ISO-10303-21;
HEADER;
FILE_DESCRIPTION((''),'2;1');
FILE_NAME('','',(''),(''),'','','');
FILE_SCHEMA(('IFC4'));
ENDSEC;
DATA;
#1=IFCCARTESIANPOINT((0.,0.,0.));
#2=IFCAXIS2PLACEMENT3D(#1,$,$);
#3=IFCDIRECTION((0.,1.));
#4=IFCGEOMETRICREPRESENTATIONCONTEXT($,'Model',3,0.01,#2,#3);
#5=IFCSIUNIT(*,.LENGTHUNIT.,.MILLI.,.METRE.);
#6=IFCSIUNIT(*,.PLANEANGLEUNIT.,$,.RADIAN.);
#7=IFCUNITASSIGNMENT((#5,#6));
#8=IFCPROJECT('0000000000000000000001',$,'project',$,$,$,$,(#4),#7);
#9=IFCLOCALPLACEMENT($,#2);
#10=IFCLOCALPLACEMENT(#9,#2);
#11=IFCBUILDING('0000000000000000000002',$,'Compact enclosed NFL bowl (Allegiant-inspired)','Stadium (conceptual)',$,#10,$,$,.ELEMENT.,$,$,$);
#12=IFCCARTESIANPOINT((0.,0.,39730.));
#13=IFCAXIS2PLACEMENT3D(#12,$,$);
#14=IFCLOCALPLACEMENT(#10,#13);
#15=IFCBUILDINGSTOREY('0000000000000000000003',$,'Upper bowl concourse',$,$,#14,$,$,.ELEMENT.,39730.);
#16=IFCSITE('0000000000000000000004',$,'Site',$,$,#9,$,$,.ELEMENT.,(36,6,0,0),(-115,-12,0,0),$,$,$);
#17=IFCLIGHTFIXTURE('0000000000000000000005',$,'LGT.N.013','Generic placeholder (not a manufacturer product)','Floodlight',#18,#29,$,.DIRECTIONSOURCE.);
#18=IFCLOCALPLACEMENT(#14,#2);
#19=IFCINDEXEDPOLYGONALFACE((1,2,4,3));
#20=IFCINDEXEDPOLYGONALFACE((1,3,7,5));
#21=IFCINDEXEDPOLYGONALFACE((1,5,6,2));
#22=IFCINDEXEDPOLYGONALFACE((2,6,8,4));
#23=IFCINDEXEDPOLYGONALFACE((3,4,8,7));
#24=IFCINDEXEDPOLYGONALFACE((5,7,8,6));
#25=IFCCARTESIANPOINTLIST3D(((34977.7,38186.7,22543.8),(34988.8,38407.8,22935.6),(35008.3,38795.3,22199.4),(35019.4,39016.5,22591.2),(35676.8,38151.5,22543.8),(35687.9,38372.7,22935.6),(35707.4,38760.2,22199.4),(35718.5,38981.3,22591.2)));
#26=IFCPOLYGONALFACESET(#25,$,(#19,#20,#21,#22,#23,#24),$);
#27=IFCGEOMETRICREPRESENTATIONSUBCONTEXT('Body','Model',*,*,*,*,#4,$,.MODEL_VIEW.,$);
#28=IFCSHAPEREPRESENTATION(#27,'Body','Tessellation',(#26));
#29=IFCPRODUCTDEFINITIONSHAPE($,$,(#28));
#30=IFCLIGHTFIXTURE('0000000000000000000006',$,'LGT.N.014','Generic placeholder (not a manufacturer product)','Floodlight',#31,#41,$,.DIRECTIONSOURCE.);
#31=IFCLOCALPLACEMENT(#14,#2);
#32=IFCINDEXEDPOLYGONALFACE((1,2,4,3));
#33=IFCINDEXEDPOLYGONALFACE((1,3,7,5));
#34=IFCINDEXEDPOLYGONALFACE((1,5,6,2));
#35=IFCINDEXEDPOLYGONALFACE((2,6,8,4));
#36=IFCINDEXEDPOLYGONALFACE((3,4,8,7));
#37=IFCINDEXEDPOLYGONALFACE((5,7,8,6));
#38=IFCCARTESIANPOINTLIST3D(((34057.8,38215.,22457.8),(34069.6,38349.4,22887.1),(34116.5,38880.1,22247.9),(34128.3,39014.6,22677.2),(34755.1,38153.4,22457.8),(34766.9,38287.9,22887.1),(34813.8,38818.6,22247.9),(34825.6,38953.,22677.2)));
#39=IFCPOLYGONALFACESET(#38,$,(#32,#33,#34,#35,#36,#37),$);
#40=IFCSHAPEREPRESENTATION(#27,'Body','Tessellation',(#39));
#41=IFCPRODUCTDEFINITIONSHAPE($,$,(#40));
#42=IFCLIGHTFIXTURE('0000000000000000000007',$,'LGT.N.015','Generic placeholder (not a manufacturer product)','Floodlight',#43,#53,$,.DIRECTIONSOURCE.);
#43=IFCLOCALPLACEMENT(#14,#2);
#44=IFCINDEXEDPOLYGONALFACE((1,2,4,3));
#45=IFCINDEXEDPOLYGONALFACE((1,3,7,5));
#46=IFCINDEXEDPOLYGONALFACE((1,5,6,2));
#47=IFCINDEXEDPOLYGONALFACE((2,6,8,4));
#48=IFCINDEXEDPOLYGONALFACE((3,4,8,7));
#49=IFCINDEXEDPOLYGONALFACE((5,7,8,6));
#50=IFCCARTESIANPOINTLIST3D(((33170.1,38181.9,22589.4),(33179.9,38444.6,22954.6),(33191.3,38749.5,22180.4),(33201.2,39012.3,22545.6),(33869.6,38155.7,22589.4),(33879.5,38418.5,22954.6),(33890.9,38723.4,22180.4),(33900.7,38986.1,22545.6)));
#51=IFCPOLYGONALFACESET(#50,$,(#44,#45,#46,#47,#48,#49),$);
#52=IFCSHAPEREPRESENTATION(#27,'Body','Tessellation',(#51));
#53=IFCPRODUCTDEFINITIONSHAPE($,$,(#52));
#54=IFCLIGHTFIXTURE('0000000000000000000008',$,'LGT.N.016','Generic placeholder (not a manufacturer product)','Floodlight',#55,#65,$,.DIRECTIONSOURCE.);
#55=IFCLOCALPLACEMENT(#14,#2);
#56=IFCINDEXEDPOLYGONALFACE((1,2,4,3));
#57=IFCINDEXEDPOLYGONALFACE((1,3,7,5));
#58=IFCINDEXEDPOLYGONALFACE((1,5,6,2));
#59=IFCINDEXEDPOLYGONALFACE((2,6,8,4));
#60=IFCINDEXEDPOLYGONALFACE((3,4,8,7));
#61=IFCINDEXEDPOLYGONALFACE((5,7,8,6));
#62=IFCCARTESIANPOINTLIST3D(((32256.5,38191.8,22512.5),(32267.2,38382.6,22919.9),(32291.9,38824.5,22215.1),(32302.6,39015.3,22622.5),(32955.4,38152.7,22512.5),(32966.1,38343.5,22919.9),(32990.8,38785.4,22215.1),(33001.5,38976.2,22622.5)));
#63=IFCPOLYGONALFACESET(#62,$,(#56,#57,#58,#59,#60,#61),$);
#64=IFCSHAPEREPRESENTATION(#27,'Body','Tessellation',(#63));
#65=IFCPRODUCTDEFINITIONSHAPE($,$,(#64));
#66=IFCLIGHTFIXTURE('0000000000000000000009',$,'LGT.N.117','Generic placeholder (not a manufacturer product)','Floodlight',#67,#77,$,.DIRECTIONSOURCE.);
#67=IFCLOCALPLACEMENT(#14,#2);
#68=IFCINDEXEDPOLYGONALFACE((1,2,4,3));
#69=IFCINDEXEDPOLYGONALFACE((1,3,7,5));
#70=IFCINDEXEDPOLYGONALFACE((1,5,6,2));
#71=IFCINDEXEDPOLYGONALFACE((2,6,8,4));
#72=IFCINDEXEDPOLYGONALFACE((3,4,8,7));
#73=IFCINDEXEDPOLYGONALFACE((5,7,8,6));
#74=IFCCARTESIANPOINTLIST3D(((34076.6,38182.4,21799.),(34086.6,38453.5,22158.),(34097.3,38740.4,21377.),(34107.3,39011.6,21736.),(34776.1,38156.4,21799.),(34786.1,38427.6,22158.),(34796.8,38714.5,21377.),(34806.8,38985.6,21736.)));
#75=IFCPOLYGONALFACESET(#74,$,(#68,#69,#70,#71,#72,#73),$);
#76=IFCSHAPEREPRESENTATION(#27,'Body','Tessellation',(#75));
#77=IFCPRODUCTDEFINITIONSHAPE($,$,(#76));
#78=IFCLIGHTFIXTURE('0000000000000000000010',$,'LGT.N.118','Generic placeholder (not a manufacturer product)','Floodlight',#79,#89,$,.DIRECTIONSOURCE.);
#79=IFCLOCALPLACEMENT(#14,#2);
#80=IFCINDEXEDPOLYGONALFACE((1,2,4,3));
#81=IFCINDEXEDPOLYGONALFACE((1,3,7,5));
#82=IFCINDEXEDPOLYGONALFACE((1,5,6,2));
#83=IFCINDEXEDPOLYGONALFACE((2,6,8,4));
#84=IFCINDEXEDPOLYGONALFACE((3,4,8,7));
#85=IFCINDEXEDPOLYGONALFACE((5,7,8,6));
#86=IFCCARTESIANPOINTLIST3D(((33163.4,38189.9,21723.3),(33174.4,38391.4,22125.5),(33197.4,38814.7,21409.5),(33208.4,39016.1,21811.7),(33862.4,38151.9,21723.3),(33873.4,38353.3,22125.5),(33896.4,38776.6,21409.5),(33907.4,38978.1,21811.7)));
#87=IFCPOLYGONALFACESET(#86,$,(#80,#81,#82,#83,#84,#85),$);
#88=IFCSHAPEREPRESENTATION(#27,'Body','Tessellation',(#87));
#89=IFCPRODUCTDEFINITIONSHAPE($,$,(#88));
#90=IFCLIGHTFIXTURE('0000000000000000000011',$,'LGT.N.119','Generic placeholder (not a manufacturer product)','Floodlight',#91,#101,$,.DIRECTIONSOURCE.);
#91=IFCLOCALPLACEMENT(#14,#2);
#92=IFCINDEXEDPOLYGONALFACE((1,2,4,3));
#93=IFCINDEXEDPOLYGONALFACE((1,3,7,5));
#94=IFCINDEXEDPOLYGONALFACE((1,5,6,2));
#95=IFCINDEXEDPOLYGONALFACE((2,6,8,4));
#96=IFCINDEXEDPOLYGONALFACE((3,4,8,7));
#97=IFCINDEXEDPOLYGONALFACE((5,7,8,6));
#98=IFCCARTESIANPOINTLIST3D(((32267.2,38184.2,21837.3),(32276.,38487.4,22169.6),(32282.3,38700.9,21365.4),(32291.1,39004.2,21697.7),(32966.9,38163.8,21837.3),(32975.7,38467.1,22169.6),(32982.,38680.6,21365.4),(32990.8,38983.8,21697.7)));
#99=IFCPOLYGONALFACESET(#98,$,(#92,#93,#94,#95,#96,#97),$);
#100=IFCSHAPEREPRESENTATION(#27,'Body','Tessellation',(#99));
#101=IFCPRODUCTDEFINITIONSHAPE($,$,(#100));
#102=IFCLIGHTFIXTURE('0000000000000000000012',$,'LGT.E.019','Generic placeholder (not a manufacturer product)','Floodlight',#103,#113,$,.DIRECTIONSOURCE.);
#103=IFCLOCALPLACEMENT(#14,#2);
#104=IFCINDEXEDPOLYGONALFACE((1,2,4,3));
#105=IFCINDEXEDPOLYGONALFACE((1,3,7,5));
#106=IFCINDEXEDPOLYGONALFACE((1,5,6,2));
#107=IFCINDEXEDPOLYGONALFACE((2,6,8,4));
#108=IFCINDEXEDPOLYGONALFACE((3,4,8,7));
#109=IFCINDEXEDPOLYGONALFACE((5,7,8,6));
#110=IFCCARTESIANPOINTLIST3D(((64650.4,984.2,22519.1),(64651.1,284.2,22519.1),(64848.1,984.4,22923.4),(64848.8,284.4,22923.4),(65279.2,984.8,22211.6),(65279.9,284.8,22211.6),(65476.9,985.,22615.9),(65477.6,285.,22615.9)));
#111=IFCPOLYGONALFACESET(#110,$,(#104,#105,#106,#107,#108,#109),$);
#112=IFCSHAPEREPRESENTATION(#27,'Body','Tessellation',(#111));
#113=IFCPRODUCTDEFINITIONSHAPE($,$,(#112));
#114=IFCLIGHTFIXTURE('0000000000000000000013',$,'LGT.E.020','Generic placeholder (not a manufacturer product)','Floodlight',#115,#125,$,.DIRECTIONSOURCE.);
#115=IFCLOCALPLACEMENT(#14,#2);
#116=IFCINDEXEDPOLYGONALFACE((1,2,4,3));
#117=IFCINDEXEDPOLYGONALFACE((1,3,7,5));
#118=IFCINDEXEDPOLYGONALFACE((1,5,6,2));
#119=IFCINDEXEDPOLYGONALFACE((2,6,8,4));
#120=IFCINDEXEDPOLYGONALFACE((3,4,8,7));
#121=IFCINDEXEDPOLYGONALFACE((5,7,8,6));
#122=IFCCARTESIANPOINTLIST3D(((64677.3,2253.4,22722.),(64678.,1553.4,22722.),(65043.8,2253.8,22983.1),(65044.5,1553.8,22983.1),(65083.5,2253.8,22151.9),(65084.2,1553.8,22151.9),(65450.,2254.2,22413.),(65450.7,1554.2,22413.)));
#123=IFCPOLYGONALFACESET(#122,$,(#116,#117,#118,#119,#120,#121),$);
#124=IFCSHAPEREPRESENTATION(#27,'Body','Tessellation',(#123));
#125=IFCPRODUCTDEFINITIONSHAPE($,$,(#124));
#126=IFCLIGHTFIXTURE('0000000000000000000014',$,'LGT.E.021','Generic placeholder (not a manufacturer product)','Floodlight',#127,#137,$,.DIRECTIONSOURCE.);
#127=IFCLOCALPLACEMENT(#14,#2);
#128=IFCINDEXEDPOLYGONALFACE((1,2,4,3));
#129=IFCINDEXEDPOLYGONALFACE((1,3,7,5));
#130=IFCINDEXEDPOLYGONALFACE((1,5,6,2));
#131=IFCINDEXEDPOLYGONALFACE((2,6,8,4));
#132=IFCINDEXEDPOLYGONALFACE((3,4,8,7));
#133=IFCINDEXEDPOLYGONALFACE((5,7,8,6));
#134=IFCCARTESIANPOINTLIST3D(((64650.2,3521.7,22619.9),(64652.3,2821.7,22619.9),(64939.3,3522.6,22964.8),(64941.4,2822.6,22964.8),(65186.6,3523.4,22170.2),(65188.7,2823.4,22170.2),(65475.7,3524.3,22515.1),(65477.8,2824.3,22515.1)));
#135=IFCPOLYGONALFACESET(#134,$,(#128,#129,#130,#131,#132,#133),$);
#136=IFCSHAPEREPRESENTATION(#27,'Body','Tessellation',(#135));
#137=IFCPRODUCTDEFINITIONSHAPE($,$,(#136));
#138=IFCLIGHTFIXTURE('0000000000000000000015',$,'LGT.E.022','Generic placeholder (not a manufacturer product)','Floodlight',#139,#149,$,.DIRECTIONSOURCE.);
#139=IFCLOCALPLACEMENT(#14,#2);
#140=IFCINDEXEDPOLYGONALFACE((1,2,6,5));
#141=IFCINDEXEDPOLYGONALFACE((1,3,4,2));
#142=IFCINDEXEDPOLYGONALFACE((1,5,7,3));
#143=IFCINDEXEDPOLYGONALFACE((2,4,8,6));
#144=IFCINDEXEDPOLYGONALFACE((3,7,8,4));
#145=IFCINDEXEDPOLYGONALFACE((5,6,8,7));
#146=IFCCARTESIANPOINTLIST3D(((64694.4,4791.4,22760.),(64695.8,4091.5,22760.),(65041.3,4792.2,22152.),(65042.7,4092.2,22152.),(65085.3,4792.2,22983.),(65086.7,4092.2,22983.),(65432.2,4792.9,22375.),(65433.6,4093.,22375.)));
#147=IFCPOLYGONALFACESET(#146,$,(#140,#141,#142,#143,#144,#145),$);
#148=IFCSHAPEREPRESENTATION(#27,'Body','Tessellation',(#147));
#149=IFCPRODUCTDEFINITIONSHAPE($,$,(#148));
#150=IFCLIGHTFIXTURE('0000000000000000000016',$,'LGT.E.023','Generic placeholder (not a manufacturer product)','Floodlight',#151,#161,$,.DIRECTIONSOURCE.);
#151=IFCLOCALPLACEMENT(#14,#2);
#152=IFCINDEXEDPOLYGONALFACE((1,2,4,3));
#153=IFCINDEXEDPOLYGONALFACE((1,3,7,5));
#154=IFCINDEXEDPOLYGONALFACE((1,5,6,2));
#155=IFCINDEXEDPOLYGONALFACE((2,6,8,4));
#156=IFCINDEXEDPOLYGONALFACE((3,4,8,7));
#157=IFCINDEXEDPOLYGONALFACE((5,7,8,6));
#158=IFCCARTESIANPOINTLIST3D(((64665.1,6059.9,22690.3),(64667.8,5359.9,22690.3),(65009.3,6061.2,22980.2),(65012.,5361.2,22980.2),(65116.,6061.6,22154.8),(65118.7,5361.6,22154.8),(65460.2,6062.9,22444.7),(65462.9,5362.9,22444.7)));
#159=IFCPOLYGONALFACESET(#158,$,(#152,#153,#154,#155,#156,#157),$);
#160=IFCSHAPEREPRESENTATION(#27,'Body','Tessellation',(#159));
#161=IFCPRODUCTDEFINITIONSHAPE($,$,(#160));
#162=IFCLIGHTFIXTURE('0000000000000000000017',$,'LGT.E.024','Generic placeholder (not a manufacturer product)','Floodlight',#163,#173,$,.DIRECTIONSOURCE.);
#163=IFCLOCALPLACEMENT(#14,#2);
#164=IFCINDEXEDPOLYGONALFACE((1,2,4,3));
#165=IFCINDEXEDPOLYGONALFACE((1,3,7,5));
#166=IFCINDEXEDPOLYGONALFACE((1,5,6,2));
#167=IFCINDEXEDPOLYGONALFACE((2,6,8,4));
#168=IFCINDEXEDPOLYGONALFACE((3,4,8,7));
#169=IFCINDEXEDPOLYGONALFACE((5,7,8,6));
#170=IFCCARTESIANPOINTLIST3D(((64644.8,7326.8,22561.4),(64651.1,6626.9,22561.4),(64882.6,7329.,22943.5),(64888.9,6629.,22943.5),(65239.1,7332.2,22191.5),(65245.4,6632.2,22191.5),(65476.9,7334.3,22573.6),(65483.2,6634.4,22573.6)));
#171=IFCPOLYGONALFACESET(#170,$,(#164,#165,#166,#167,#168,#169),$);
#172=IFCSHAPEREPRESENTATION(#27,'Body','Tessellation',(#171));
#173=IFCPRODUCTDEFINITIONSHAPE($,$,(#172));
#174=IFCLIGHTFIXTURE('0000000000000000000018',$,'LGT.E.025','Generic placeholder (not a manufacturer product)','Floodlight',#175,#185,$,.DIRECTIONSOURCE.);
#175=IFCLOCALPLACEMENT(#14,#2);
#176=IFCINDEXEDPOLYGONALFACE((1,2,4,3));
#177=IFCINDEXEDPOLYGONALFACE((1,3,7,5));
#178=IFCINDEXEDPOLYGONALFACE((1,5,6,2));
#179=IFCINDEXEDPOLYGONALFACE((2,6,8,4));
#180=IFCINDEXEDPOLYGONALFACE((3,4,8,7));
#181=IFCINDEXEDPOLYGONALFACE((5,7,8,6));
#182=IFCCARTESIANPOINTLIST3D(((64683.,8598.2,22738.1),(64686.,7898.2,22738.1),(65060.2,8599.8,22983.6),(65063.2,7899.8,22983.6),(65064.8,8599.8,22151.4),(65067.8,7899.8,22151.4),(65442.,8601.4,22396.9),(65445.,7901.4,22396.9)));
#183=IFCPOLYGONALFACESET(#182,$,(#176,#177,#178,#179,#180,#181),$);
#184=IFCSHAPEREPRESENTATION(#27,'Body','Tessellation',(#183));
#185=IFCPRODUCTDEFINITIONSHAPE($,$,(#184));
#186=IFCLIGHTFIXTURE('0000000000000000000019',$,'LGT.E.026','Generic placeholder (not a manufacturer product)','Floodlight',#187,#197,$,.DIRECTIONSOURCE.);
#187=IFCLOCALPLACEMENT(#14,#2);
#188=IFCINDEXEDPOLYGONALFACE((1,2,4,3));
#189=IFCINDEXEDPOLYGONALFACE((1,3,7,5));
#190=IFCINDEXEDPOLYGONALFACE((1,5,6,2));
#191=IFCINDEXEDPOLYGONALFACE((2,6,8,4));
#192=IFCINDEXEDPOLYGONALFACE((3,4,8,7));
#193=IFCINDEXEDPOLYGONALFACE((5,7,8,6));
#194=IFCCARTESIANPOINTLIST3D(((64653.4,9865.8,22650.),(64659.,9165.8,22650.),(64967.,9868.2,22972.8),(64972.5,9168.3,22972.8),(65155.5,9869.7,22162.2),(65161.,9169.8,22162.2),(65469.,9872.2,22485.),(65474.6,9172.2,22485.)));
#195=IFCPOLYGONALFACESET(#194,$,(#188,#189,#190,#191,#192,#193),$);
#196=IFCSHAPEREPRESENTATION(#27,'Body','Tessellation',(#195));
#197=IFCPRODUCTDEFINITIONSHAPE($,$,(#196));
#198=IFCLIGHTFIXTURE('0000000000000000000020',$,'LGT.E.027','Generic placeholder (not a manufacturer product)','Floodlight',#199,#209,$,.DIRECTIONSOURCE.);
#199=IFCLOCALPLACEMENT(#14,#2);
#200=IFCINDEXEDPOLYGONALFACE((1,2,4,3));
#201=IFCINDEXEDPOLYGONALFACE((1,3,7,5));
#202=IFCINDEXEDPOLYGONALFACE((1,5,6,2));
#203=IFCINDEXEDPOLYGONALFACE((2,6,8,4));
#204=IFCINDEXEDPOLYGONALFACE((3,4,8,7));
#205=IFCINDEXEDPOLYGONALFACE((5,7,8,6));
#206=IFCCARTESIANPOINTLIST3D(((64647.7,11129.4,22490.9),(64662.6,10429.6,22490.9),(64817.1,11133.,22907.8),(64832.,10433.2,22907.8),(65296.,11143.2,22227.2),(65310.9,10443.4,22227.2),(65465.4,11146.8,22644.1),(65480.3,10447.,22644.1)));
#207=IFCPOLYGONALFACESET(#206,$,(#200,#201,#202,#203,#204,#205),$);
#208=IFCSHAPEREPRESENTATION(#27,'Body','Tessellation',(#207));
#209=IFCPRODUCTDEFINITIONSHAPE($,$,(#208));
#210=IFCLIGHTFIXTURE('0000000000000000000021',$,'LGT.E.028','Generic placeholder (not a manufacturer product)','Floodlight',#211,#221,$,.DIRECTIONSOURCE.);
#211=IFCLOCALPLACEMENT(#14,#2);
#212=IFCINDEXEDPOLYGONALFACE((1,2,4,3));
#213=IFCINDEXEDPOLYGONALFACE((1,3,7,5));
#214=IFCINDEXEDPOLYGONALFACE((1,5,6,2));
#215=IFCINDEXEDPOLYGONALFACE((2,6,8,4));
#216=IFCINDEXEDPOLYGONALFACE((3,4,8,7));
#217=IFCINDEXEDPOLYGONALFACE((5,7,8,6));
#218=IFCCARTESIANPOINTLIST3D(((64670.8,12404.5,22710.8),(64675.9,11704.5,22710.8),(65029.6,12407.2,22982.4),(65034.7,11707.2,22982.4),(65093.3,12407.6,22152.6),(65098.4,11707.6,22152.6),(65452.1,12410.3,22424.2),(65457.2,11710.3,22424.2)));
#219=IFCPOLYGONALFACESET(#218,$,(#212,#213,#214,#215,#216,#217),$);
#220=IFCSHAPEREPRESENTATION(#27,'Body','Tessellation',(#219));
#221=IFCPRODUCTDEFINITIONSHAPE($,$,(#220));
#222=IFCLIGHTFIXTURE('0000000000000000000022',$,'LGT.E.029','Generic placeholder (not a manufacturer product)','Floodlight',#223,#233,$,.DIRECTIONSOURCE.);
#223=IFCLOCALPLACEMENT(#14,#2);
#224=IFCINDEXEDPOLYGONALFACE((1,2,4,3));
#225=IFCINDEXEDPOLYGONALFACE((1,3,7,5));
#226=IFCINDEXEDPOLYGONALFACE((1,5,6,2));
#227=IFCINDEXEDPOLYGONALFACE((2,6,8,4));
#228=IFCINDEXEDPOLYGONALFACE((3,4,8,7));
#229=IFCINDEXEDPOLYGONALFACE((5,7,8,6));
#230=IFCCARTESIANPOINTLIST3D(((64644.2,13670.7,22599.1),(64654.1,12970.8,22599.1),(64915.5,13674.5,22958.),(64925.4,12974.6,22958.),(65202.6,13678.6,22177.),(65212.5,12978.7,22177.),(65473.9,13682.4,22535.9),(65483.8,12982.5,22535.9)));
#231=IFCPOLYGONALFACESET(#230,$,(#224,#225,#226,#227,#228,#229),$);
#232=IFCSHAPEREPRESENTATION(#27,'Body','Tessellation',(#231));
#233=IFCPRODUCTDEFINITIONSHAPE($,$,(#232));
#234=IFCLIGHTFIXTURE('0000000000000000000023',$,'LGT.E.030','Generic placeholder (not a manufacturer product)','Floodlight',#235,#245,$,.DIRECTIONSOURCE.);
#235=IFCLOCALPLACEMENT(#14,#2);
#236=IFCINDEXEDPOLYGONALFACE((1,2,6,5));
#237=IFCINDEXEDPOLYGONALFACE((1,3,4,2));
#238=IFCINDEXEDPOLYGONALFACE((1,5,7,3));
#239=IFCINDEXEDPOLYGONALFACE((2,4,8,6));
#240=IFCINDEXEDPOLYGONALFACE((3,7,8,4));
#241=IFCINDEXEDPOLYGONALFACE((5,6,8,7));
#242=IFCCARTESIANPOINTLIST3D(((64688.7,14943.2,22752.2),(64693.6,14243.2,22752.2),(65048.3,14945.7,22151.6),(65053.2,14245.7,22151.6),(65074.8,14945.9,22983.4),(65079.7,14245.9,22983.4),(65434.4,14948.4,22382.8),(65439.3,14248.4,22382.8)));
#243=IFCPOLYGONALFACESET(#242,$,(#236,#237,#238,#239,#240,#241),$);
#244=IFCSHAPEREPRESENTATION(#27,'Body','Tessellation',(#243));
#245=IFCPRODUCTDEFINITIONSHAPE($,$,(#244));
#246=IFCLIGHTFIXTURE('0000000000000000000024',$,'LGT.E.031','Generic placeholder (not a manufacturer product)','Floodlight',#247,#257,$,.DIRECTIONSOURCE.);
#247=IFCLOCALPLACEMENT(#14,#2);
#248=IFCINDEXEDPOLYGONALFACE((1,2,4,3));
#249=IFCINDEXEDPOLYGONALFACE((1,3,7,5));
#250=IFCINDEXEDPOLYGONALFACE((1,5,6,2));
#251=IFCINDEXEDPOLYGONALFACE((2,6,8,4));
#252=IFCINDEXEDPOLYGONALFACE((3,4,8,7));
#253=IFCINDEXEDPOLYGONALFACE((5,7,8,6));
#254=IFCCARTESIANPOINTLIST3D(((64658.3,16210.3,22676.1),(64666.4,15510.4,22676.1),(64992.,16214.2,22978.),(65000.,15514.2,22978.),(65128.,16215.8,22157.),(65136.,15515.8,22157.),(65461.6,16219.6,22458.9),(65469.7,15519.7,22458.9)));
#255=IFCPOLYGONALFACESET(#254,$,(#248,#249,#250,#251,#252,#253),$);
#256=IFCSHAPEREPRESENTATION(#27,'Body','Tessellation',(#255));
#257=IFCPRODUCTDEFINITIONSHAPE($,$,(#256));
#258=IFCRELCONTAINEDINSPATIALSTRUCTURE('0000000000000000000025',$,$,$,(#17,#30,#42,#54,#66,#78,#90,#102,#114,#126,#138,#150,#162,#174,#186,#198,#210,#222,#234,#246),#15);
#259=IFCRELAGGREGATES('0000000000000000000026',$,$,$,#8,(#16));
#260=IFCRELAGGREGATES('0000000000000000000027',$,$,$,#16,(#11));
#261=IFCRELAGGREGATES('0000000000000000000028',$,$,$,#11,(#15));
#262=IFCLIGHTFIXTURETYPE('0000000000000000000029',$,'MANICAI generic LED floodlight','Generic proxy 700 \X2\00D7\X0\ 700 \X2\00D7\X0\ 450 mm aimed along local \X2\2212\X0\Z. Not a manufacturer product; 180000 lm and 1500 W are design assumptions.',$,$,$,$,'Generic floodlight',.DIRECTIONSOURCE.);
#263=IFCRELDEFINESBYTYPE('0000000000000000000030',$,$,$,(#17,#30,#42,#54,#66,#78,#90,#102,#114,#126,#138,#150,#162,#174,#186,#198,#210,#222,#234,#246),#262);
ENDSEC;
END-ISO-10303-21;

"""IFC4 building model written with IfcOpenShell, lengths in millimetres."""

from ifc_helpers import new_model, si_unit, direction, frame, origin, place, context, subcontext, project, spatial, rectangle, extrude, source, transform, mapped, type_object, type_shapes, element, save


model = new_model("IFC4")

# Units and contexts
model_context = context("Model", 3, precision=0.01, world=origin(), true_north=direction((0.0, 1.0)))
body_context = subcontext(model_context, "Body", "Model", "MODEL_VIEW")
ifc_project = project(units=[si_unit("LENGTHUNIT", "METRE", prefix="MILLI"), si_unit("PLANEANGLEUNIT", "RADIAN")], contexts=[model_context])

# Site, building, storey
site_placement = place(None, origin())
site = spatial("IfcSite", under=ifc_project, at=site_placement, Name="Site", CompositionType="ELEMENT", RefLatitude=(36, 6, 0, 0), RefLongitude=(-115, -12, 0, 0))
building_placement = place(site_placement, origin())
building = spatial("IfcBuilding", under=site, at=building_placement, Name="Compact enclosed NFL bowl (Allegiant-inspired)", Description="Stadium (conceptual)", CompositionType="ELEMENT")
storey_placement = place(building_placement, frame((0.0, 0.0, 39730.0)))
storey = spatial("IfcBuildingStorey", under=building, at=storey_placement, Name="Upper bowl concourse", CompositionType="ELEMENT", Elevation=39730.0)

# Light fixtures
light_fixture_type = type_object("IfcLightFixtureType", Name="MANICAI generic LED floodlight", Description="Generic proxy 700 × 700 × 450 mm aimed along local −Z. Not a manufacturer product; 180000 lm and 1500 W are design assumptions.", ElementType="Generic floodlight", PredefinedType="DIRECTIONSOURCE")
shared_shape = source(origin(), body_context, "Body", "SweptSolid", [
    extrude(rectangle(XDim=700.0, YDim=700.0), frame((0.0, 0.0, -225.0)), (0.0, 0.0, 1.0), 450.0),
])
type_shapes(light_fixture_type, [shared_shape])
for number, where, z_axis, x_axis, name in (
    (1, (35348.1, 38584.0, 22567.5), (0.0247, 0.491356, 0.870608), (-0.998739, 0.050205, 0.0), "LGT.N.013"),
    (2, (34441.7, 38584.0, 22567.5), (0.02637, 0.29879, 0.953954), (-0.996128, 0.087914, 0.0), "LGT.N.014"),
    (3, (33535.4, 38584.0, 22567.5), (0.021842, 0.583959, 0.811489), (-0.999301, 0.037377, 0.0), "LGT.N.015"),
    (4, (32629.0, 38584.0, 22567.5), (0.023708, 0.424088, 0.905311), (-0.998441, 0.055817, 0.0), "LGT.N.016"),
    (5, (34441.7, 38584.0, 21767.5), (0.02234, 0.602536, 0.797779), (-0.999313, 0.037051, 0.0), "LGT.N.117"),
    (6, (33535.4, 38584.0, 21767.5), (0.024372, 0.447673, 0.893865), (-0.998521, 0.054361, 0.0), "LGT.N.118"),
    (7, (32629.0, 38584.0, 21767.5), (0.019592, 0.673928, 0.738537), (-0.999578, 0.02906, 0.0), "LGT.N.119"),
    (8, (65064.0, 634.6, 22567.5), (0.439296, 0.000458, 0.898342), (-0.001042, 0.999999, 0.0), "LGT.E.019"),
    (9, (65064.0, 1903.8, 22567.5), (0.814402, 0.000887, 0.580301), (-0.001089, 0.999999, 0.0), "LGT.E.020"),
    (10, (65064.0, 3173.0, 22567.5), (0.642417, 0.001952, 0.766353), (-0.003038, 0.999995, 0.0), "LGT.E.021"),
    (11, (65064.0, 4442.2, 22567.5), (0.868569, 0.001767, 0.495565), (-0.002034, 0.999998, 0.0), "LGT.E.022"),
    (12, (65064.0, 5711.4, 22567.5), (0.764921, 0.002953, 0.644117), (-0.00386, 0.999993, 0.0), "LGT.E.023"),
    (13, (65064.0, 6980.6, 22567.5), (0.528415, 0.004756, 0.848973), (-0.009001, 0.999959, 0.0), "LGT.E.024"),
    (14, (65064.0, 8249.8, 22567.5), (0.838172, 0.003611, 0.545393), (-0.004308, 0.999991, 0.0), "LGT.E.025"),
    (15, (65064.0, 9519.0, 22567.5), (0.696871, 0.005479, 0.717175), (-0.007862, 0.999969, 0.0), "LGT.E.026"),
    (16, (65064.0, 10788.2, 22567.5), (0.376607, 0.008021, 0.926338), (-0.021293, 0.999773, 0.0), "LGT.E.027"),
    (17, (65064.0, 12057.4, 22567.5), (0.79729, 0.005841, 0.603568), (-0.007326, 0.999973, 0.0), "LGT.E.028"),
    (18, (65064.0, 13326.6, 22567.5), (0.602949, 0.008533, 0.797734), (-0.01415, 0.9999, 0.0), "LGT.E.029"),
    (19, (65064.0, 14595.8, 22567.5), (0.857962, 0.006018, 0.513678), (-0.007014, 0.999975, 0.0), "LGT.E.030"),
    (20, (65064.0, 15865.0, 22567.5), (0.741459, 0.008543, 0.670944), (-0.011522, 0.999934, 0.0), "LGT.E.031"),
):
    element("IfcLightFixture", number, at=place(storey_placement, frame(where, z_axis=z_axis, x_axis=x_axis)), inside=storey, type_object=light_fixture_type, Name=name, Description="Generic placeholder (not a manufacturer product)", ObjectType="Floodlight", PredefinedType="DIRECTIONSOURCE", context=body_context, shape_type="MappedRepresentation", body=[
        mapped(shared_shape, transform((0.0, 0.0, 0.0))),
    ])

save(model, "model.ifc")
